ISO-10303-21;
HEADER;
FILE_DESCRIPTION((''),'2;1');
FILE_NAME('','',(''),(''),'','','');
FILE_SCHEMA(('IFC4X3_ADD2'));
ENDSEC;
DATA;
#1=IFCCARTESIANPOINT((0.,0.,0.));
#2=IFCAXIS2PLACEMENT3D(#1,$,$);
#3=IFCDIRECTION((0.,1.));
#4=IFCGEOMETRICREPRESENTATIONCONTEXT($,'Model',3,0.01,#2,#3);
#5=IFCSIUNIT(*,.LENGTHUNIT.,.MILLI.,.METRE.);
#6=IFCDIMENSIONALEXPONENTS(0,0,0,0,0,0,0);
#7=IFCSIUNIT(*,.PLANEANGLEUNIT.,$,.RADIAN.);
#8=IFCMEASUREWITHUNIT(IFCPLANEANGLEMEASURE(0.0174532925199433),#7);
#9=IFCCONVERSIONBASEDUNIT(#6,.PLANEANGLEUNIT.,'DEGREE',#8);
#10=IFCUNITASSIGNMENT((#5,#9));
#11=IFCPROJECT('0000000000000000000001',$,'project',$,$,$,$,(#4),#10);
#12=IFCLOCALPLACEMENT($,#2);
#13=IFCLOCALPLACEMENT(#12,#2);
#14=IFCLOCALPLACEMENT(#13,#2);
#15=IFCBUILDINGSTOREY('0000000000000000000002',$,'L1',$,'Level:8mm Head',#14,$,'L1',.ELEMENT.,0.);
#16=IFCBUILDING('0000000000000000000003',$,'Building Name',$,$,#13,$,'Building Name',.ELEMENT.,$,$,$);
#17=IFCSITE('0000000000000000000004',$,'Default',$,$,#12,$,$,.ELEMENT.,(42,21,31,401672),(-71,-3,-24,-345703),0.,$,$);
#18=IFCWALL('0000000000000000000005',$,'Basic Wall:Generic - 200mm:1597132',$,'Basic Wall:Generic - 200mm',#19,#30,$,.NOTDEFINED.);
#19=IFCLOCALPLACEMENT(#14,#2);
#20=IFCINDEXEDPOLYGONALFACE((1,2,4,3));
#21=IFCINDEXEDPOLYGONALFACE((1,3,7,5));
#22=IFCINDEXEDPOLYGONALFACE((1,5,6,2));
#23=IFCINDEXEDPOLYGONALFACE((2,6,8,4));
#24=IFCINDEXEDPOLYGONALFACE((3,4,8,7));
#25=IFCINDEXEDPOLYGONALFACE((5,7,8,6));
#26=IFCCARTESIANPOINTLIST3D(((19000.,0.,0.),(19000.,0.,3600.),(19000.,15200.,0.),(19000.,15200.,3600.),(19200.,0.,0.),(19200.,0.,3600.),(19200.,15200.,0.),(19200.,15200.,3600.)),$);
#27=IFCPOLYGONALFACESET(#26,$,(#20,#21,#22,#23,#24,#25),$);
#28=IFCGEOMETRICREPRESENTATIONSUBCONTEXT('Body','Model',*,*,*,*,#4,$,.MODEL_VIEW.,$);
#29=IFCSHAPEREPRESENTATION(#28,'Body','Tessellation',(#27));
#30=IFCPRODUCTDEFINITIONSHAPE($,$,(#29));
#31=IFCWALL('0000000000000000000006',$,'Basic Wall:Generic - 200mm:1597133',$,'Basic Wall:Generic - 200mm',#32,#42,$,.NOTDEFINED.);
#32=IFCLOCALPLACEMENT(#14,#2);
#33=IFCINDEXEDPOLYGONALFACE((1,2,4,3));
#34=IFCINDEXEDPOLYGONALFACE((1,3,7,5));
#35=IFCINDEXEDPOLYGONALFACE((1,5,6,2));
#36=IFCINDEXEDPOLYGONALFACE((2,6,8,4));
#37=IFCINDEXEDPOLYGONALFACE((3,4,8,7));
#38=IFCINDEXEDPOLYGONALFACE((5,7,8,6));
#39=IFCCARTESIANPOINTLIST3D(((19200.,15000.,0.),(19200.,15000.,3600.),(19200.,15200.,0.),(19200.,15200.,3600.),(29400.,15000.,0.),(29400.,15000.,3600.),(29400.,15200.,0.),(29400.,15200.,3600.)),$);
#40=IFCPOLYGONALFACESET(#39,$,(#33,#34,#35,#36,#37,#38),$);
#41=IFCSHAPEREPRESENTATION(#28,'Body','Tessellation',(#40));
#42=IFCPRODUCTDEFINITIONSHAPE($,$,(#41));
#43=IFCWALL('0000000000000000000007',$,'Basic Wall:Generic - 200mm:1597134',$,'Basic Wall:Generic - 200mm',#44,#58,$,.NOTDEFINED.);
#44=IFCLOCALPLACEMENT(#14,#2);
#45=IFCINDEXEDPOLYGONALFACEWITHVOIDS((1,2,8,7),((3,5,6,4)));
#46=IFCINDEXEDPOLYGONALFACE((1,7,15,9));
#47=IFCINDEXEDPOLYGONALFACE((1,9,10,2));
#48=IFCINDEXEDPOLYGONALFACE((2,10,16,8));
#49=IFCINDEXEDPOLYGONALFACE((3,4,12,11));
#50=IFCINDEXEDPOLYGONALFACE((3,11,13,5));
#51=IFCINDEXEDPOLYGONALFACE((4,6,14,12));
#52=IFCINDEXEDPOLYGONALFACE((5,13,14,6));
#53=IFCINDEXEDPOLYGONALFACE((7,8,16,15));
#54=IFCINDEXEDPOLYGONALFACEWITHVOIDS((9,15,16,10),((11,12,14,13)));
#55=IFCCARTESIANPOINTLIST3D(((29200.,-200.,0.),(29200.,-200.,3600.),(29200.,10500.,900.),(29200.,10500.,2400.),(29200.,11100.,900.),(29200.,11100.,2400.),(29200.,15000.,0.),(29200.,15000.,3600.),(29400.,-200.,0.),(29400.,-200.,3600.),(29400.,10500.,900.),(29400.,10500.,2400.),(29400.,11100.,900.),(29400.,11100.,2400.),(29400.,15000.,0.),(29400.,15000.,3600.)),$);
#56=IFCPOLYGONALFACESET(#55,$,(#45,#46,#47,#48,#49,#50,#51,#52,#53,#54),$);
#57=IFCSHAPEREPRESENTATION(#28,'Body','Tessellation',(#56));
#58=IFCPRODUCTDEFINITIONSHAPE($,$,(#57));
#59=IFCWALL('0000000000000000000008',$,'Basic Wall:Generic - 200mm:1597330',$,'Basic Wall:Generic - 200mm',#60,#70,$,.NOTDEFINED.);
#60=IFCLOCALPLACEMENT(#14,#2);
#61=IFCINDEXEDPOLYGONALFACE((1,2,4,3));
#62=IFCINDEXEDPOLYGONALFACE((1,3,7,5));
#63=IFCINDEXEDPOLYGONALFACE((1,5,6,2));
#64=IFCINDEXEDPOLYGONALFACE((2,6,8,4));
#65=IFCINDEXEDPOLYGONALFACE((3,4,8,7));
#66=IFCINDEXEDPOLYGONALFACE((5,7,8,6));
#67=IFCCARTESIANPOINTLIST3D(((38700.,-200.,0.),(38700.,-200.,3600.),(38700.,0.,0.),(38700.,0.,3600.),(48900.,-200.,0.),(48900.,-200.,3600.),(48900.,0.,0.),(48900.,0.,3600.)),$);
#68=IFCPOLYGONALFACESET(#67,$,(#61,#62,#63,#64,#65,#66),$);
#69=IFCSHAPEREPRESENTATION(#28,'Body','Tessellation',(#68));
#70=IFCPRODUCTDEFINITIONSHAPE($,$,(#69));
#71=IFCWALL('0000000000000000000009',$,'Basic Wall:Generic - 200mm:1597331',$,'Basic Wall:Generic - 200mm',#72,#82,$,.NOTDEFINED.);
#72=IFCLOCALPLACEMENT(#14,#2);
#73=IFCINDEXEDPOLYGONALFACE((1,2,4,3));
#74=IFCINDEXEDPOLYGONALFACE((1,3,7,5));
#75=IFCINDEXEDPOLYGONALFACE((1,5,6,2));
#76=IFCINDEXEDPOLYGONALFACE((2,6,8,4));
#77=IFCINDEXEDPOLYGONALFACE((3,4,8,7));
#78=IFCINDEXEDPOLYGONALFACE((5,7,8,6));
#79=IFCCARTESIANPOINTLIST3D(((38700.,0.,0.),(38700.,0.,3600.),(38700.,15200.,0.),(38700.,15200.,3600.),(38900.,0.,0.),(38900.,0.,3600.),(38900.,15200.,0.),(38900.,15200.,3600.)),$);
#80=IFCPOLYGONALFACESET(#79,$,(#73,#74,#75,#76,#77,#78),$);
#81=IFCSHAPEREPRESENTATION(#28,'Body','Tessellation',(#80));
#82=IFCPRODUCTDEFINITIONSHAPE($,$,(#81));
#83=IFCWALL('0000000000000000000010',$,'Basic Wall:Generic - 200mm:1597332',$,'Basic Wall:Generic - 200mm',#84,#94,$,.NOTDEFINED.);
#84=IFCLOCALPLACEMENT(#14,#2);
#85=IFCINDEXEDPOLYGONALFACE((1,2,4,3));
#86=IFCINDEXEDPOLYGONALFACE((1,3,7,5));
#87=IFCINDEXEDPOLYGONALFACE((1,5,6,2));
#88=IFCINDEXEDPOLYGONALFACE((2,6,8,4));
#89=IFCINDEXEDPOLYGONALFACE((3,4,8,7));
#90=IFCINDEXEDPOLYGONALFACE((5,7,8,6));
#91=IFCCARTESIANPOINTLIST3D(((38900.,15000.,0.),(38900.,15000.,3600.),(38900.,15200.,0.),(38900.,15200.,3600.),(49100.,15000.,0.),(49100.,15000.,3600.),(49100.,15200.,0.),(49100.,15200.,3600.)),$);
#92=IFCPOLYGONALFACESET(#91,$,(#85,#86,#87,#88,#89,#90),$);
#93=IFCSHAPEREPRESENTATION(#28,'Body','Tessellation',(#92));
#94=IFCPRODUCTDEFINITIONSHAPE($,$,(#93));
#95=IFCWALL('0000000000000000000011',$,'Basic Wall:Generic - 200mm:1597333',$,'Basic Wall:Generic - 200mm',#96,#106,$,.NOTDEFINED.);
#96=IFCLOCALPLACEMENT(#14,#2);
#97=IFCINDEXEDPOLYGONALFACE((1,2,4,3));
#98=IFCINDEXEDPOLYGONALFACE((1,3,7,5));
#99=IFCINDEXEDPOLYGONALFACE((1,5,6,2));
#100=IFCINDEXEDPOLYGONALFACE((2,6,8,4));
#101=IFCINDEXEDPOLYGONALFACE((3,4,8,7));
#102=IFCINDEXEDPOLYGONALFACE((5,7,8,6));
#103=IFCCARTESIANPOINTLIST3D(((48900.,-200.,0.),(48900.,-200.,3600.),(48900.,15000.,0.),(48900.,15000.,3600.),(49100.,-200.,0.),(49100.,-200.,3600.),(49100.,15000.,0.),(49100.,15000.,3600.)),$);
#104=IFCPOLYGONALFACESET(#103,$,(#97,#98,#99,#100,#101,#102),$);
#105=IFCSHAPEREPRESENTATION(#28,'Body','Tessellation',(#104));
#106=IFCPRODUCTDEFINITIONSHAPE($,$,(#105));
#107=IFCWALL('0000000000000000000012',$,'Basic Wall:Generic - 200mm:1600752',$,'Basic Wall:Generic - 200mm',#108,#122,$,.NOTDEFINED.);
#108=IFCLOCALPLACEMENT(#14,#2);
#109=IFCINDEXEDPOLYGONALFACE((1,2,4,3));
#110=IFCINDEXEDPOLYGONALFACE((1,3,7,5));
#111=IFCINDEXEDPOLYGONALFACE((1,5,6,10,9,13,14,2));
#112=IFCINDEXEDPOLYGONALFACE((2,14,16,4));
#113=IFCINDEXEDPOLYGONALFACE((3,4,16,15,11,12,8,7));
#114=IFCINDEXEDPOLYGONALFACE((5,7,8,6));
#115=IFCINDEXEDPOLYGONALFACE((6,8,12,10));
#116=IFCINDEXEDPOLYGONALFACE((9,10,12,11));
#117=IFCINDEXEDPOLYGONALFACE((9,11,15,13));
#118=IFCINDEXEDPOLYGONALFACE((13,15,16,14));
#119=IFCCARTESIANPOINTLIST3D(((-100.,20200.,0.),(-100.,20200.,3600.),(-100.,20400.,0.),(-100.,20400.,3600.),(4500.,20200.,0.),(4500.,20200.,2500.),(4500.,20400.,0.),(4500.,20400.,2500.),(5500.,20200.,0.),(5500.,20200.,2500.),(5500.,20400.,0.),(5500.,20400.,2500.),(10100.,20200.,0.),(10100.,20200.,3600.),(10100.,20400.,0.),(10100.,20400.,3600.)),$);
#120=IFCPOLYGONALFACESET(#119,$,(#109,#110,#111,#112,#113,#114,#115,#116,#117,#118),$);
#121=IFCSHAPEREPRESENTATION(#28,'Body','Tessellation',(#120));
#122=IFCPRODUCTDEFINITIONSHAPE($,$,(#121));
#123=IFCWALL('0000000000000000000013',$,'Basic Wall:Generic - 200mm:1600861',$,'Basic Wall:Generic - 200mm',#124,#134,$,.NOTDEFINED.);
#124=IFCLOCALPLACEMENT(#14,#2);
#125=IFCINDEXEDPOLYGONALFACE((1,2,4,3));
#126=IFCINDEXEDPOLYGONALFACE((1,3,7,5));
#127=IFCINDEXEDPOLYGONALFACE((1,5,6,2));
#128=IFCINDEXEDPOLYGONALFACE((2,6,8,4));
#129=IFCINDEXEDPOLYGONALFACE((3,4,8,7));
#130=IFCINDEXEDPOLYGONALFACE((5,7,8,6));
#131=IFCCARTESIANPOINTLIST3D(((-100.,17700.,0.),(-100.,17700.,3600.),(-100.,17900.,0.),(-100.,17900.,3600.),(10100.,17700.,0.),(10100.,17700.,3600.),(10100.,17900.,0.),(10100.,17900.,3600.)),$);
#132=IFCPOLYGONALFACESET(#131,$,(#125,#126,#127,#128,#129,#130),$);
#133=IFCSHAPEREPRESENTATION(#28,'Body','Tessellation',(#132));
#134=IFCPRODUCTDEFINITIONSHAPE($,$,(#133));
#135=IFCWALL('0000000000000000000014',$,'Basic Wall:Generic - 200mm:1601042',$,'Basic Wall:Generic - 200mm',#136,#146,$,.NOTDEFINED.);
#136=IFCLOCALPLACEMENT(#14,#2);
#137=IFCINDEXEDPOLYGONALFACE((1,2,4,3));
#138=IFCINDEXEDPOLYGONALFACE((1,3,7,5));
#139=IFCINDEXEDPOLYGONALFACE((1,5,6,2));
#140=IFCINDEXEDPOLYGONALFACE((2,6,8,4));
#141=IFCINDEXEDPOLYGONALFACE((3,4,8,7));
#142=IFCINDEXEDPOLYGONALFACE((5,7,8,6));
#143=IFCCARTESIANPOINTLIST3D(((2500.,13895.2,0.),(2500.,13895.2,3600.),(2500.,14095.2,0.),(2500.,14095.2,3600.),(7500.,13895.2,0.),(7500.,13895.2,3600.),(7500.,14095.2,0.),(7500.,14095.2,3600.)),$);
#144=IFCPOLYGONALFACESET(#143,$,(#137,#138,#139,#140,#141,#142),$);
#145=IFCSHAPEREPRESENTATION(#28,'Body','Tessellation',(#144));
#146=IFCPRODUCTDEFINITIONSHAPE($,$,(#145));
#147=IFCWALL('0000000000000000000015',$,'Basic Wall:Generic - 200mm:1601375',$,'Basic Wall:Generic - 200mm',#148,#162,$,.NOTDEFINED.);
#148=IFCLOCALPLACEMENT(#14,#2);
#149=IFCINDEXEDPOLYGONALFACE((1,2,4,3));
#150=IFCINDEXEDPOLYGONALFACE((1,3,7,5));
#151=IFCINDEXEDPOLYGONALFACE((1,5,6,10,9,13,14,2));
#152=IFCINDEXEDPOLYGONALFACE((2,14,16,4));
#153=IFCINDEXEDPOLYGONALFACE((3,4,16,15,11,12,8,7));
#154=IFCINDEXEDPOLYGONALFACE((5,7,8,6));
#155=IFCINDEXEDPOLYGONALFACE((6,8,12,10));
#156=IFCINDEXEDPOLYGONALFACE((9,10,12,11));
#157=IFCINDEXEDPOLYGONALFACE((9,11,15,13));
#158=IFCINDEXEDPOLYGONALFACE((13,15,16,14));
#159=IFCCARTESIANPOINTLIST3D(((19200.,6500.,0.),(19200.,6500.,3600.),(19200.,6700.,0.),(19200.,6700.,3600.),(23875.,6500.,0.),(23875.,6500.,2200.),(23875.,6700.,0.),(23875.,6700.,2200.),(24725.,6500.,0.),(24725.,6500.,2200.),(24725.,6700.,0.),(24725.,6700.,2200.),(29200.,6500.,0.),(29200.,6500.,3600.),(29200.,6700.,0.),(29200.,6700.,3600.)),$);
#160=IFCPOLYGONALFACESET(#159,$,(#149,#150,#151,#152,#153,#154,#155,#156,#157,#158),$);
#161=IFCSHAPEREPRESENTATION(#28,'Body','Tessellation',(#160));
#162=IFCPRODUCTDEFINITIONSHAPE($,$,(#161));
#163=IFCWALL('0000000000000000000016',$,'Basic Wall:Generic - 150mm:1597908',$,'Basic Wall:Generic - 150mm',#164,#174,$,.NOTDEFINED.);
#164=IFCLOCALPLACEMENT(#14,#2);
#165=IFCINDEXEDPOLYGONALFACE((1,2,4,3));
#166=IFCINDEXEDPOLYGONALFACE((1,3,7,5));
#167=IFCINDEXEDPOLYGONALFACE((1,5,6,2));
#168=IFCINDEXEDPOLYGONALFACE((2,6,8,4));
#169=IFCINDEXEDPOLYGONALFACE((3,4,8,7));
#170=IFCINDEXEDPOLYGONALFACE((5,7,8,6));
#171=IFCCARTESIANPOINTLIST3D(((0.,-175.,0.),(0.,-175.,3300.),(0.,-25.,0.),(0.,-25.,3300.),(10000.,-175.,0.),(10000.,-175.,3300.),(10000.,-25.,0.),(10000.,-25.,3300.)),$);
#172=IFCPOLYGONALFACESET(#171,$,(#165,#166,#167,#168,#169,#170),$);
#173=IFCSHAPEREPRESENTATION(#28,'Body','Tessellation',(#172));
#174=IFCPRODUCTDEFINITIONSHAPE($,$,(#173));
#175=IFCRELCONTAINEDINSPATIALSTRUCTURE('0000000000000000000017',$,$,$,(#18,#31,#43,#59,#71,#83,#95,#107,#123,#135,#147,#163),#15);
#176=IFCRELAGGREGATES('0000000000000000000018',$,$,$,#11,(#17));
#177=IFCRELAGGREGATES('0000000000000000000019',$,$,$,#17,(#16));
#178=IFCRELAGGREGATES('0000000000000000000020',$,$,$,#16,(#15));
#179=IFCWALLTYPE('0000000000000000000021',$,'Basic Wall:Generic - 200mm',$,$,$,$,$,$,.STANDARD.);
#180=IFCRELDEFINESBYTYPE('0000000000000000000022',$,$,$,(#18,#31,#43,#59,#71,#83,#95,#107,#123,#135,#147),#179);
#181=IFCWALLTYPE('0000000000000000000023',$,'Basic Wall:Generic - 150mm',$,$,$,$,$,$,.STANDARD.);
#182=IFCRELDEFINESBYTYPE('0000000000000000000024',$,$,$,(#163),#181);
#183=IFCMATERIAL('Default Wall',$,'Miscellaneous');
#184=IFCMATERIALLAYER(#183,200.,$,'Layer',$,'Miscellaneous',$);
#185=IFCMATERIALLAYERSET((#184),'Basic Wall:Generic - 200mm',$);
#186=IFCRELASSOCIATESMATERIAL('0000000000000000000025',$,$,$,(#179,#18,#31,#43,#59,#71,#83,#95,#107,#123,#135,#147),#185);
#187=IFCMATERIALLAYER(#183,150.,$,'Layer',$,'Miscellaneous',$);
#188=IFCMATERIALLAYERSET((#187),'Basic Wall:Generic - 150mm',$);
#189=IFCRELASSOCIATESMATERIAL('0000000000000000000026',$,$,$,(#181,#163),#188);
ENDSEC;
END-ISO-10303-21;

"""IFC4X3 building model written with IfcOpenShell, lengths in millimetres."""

from ifc_helpers import new_model, entity, si_unit, converted_unit, direction, frame, frame_2d, origin, origin_2d_with_axis, place, context, subcontext, project, spatial, rectangle, extrude, material, layer, layer_set, type_object, element, save


model = new_model("IFC4X3")

# Units and contexts
model_context = context("Model", 3, precision=0.01, world=origin(), true_north=direction((0.0, 1.0)))
body_context = subcontext(model_context, "Body", "Model", "MODEL_VIEW")
ifc_project = project(units=[si_unit("LENGTHUNIT", "METRE", prefix="MILLI"), converted_unit("PLANEANGLEUNIT", "DEGREE", entity("IfcPlaneAngleMeasure", 0.0174532925199433), si_unit("PLANEANGLEUNIT", "RADIAN"), dimensions=[0, 0, 0, 0, 0, 0, 0])], contexts=[model_context])

# Site, building, storey
site_placement = place(None, origin())
site = spatial("IfcSite", under=ifc_project, at=site_placement, Name="Default", CompositionType="ELEMENT", RefLatitude=(42, 21, 31, 401672), RefLongitude=(-71, -3, -24, -345703), RefElevation=0.0)
building_placement = place(site_placement, origin())
building = spatial("IfcBuilding", under=site, at=building_placement, Name="Building Name", LongName="Building Name", CompositionType="ELEMENT")
storey_placement = place(building_placement, origin())
storey = spatial("IfcBuildingStorey", under=building, at=storey_placement, Name="L1", ObjectType="Level:8mm Head", LongName="L1", CompositionType="ELEMENT", Elevation=0.0)

# Walls
ifc_material_1 = material(Name="Default Wall", Category="Miscellaneous")
ifc_layer_1 = layer(ifc_material_1, 200.0, Name="Layer", Category="Miscellaneous")
ifc_layer_set_1 = layer_set([ifc_layer_1], Name="Basic Wall:Generic - 200mm")
wall_type_1 = type_object("IfcWallType", Name="Basic Wall:Generic - 200mm", PredefinedType="STANDARD", material=ifc_layer_set_1)
wall_1_placement = place(storey_placement, frame((19100.0, 15200.0, 0.0), z_axis=(0.0, 0.0, 1.0), x_axis=(0.0, -1.0, 0.0)))
element("IfcWall", 1, at=wall_1_placement, inside=storey, type_object=wall_type_1, material=ifc_layer_set_1, Name="Basic Wall:Generic - 200mm:1597132", ObjectType="Basic Wall:Generic - 200mm", PredefinedType="NOTDEFINED", context=body_context, shape_type="SweptSolid", body=[
    extrude(rectangle(XDim=15200.0, YDim=200.0, at=frame_2d((7600.0, 0.0), x_axis=(-1.0, 0.0))), origin(), (0.0, 0.0, 1.0), 3600.0),
])
wall_2_placement = place(storey_placement, frame((29400.0, 15100.0, 0.0), z_axis=(0.0, 0.0, 1.0), x_axis=(-1.0, 0.0, 0.0)))
element("IfcWall", 2, at=wall_2_placement, inside=storey, type_object=wall_type_1, material=ifc_layer_set_1, Name="Basic Wall:Generic - 200mm:1597133", ObjectType="Basic Wall:Generic - 200mm", PredefinedType="NOTDEFINED", context=body_context, shape_type="SweptSolid", body=[
    extrude(rectangle(XDim=10200.0, YDim=200.0, at=frame_2d((5100.0, 0.0), x_axis=(-1.0, 0.0))), origin(), (0.0, 0.0, 1.0), 3600.0),
])

# Wall, opening
wall_3_placement = place(storey_placement, frame((29300.0, -200.0, 0.0), z_axis=(0.0, 0.0, 1.0), x_axis=(0.0, 1.0, 0.0)))
wall_3 = element("IfcWall", 3, at=wall_3_placement, inside=storey, type_object=wall_type_1, material=ifc_layer_set_1, Name="Basic Wall:Generic - 200mm:1597134", ObjectType="Basic Wall:Generic - 200mm", PredefinedType="NOTDEFINED", context=body_context, shape_type="SweptSolid", body=[
    extrude(rectangle(XDim=15200.0, YDim=200.0, at=frame_2d((7600.0, 0.0), x_axis=(-1.0, 0.0))), origin(), (0.0, 0.0, 1.0), 3600.0),
])
opening_1_placement = place(wall_3_placement, frame((11300.0, 100.0, 900.0)))
element("IfcOpeningElement", 4, at=opening_1_placement, cuts=wall_3, PredefinedType="OPENING", context=body_context, shape_type="SweptSolid", body=[
    extrude(rectangle(XDim=1500.0, YDim=600.0, at=frame_2d((750.0, 300.0), x_axis=(-1.0, 0.0))), frame((0.0, 0.0, 0.0), z_axis=(0.0, -1.0, 0.0), x_axis=(0.0, 0.0, 1.0)), (0.0, 0.0, 1.0), 200.0),
])

# Walls
wall_4_placement = place(storey_placement, frame((38700.0, -100.0, 0.0)))
element("IfcWall", 5, at=wall_4_placement, inside=storey, type_object=wall_type_1, material=ifc_layer_set_1, Name="Basic Wall:Generic - 200mm:1597330", ObjectType="Basic Wall:Generic - 200mm", PredefinedType="NOTDEFINED", context=body_context, shape_type="SweptSolid", body=[
    extrude(rectangle(XDim=10200.0, YDim=200.0, at=frame_2d((5100.0, 0.0), x_axis=(-1.0, 0.0))), origin(), (0.0, 0.0, 1.0), 3600.0),
])
wall_5_placement = place(storey_placement, frame((38800.0, 15200.0, 0.0), z_axis=(0.0, 0.0, 1.0), x_axis=(0.0, -1.0, 0.0)))
element("IfcWall", 6, at=wall_5_placement, inside=storey, type_object=wall_type_1, material=ifc_layer_set_1, Name="Basic Wall:Generic - 200mm:1597331", ObjectType="Basic Wall:Generic - 200mm", PredefinedType="NOTDEFINED", context=body_context, shape_type="SweptSolid", body=[
    extrude(rectangle(XDim=15200.0, YDim=200.0, at=frame_2d((7600.0, 0.0), x_axis=(-1.0, 0.0))), origin(), (0.0, 0.0, 1.0), 3600.0),
])
wall_6_placement = place(storey_placement, frame((49100.0, 15100.0, 0.0), z_axis=(0.0, 0.0, 1.0), x_axis=(-1.0, 0.0, 0.0)))
element("IfcWall", 7, at=wall_6_placement, inside=storey, type_object=wall_type_1, material=ifc_layer_set_1, Name="Basic Wall:Generic - 200mm:1597332", ObjectType="Basic Wall:Generic - 200mm", PredefinedType="NOTDEFINED", context=body_context, shape_type="SweptSolid", body=[
    extrude(rectangle(XDim=10200.0, YDim=200.0, at=frame_2d((5100.0, 0.0), x_axis=(-1.0, 0.0))), origin(), (0.0, 0.0, 1.0), 3600.0),
])
wall_7_placement = place(storey_placement, frame((49000.0, -200.0, 0.0), z_axis=(0.0, 0.0, 1.0), x_axis=(0.0, 1.0, 0.0)))
element("IfcWall", 8, at=wall_7_placement, inside=storey, type_object=wall_type_1, material=ifc_layer_set_1, Name="Basic Wall:Generic - 200mm:1597333", ObjectType="Basic Wall:Generic - 200mm", PredefinedType="NOTDEFINED", context=body_context, shape_type="SweptSolid", body=[
    extrude(rectangle(XDim=15200.0, YDim=200.0, at=frame_2d((7600.0, 0.0), x_axis=(-1.0, 0.0))), origin(), (0.0, 0.0, 1.0), 3600.0),
])

# Wall, opening
wall_8_placement = place(storey_placement, frame((10100.0, 20300.0, 0.0), z_axis=(0.0, 0.0, 1.0), x_axis=(-1.0, 0.0, 0.0)))
wall_8 = element("IfcWall", 9, at=wall_8_placement, inside=storey, type_object=wall_type_1, material=ifc_layer_set_1, Name="Basic Wall:Generic - 200mm:1600752", ObjectType="Basic Wall:Generic - 200mm", PredefinedType="NOTDEFINED", context=body_context, shape_type="SweptSolid", body=[
    extrude(rectangle(XDim=10200.0, YDim=200.0, at=frame_2d((5100.0, 0.0), x_axis=(1.0, 0.0))), origin(), (0.0, 0.0, 1.0), 3600.0),
])
opening_2_placement = place(wall_8_placement, frame((5600.0, 100.0, 0.0)))
element("IfcOpeningElement", 10, at=opening_2_placement, cuts=wall_8, PredefinedType="OPENING", context=body_context, shape_type="SweptSolid", body=[
    extrude(rectangle(XDim=2500.0, YDim=1000.0, at=origin_2d_with_axis()), frame((-500.0, -200.0, 1250.0), z_axis=(0.0, 1.0, 0.0), x_axis=(0.0, 0.0, -1.0)), (0.0, 0.0, 1.0), 200.0),
])

# Walls
wall_9_placement = place(storey_placement, frame((10100.0, 17800.0, 0.0), z_axis=(0.0, 0.0, 1.0), x_axis=(-1.0, 0.0, 0.0)))
element("IfcWall", 11, at=wall_9_placement, inside=storey, type_object=wall_type_1, material=ifc_layer_set_1, Name="Basic Wall:Generic - 200mm:1600861", ObjectType="Basic Wall:Generic - 200mm", PredefinedType="NOTDEFINED", context=body_context, shape_type="SweptSolid", body=[
    extrude(rectangle(XDim=10200.0, YDim=200.0, at=frame_2d((5100.0, 0.0), x_axis=(-1.0, 0.0))), origin(), (0.0, 0.0, 1.0), 3600.0),
])
wall_10_placement = place(storey_placement, frame((7500.0, 13995.2, 0.0), z_axis=(0.0, 0.0, 1.0), x_axis=(-1.0, 0.0, 0.0)))
element("IfcWall", 12, at=wall_10_placement, inside=storey, type_object=wall_type_1, material=ifc_layer_set_1, Name="Basic Wall:Generic - 200mm:1601042", ObjectType="Basic Wall:Generic - 200mm", PredefinedType="NOTDEFINED", context=body_context, shape_type="SweptSolid", body=[
    extrude(rectangle(XDim=5000.0, YDim=200.0, at=frame_2d((2500.0, 0.0), x_axis=(-1.0, 0.0))), origin(), (0.0, 0.0, 1.0), 3600.0),
])

# Wall, opening
wall_11_placement = place(storey_placement, frame((29200.0, 6600.0, 0.0), z_axis=(0.0, 0.0, 1.0), x_axis=(-1.0, 0.0, 0.0)))
wall_11 = element("IfcWall", 13, at=wall_11_placement, inside=storey, type_object=wall_type_1, material=ifc_layer_set_1, Name="Basic Wall:Generic - 200mm:1601375", ObjectType="Basic Wall:Generic - 200mm", PredefinedType="NOTDEFINED", context=body_context, shape_type="SweptSolid", body=[
    extrude(rectangle(XDim=10000.0, YDim=200.0, at=frame_2d((5000.0, 0.0), x_axis=(1.0, 0.0))), origin(), (0.0, 0.0, 1.0), 3600.0),
])
opening_3_placement = place(wall_11_placement, frame((5325.0, 100.0, 0.0)))
element("IfcOpeningElement", 14, at=opening_3_placement, cuts=wall_11, PredefinedType="OPENING", context=body_context, shape_type="SweptSolid", body=[
    extrude(rectangle(XDim=2200.0, YDim=850.0, at=frame_2d((1100.0, 425.0), x_axis=(1.0, 0.0))), frame((0.0, 0.0, 0.0), z_axis=(0.0, -1.0, 0.0), x_axis=(0.0, 0.0, 1.0)), (0.0, 0.0, 1.0), 200.0),
])

# Wall
ifc_layer_2 = layer(ifc_material_1, 150.0, Name="Layer", Category="Miscellaneous")
ifc_layer_set_2 = layer_set([ifc_layer_2], Name="Basic Wall:Generic - 150mm")
wall_type_2 = type_object("IfcWallType", Name="Basic Wall:Generic - 150mm", PredefinedType="STANDARD", material=ifc_layer_set_2)
wall_12_placement = place(storey_placement, frame((0.0, -100.0, 0.0)))
element("IfcWall", 15, at=wall_12_placement, inside=storey, type_object=wall_type_2, material=ifc_layer_set_2, Name="Basic Wall:Generic - 150mm:1597908", ObjectType="Basic Wall:Generic - 150mm", PredefinedType="NOTDEFINED", context=body_context, shape_type="SweptSolid", body=[
    extrude(rectangle(XDim=10000.0, YDim=150.0, at=frame_2d((5000.0, 0.0), x_axis=(-1.0, 0.0))), origin(), (0.0, 0.0, 1.0), 3300.0),
])

save(model, "model.ifc")
